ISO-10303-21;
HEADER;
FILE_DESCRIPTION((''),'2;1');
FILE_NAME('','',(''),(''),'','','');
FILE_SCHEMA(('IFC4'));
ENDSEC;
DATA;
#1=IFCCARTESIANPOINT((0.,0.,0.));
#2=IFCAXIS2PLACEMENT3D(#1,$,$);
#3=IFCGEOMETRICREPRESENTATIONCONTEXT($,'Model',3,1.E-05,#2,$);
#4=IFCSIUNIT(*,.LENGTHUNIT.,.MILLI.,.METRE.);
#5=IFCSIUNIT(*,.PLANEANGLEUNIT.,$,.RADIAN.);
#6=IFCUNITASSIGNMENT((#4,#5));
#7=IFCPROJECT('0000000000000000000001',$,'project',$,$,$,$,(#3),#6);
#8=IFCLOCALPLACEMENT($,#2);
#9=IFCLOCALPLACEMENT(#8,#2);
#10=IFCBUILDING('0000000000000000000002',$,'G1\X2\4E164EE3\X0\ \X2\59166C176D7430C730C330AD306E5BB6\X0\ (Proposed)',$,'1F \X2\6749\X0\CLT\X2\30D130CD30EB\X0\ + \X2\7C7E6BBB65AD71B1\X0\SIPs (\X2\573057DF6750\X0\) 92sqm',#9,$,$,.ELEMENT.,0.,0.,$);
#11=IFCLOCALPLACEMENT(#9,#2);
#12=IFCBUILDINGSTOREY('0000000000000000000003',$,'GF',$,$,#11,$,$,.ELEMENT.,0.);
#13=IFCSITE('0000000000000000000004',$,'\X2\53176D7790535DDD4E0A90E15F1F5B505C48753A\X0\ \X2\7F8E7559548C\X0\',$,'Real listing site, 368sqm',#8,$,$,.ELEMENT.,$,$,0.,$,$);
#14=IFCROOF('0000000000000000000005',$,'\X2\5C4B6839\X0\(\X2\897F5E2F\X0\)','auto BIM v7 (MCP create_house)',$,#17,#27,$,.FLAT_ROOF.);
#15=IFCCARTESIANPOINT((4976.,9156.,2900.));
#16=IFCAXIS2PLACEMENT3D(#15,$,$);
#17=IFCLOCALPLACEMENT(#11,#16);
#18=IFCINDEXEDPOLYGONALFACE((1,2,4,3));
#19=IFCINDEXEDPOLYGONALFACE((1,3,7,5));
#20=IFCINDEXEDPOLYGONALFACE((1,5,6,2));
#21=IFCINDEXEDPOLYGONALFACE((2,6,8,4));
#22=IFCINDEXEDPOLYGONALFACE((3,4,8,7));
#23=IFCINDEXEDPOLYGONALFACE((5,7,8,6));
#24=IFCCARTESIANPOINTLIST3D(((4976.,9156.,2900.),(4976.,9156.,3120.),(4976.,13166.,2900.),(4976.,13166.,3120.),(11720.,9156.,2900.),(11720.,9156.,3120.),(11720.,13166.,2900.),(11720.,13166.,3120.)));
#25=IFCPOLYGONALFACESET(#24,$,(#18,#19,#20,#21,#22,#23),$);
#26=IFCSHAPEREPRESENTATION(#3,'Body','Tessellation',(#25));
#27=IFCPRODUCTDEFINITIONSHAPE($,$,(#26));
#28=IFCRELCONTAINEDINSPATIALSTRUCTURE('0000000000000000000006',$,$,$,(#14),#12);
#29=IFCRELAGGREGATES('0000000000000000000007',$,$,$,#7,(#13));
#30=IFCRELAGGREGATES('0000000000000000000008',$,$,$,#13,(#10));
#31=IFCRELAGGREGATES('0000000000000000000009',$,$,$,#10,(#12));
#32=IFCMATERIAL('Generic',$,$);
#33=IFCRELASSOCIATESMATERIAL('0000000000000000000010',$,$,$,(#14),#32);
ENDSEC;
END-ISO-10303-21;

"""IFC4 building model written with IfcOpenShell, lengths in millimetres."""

from ifc_helpers import new_model, si_unit, frame, frame_2d, origin, place, context, project, spatial, rectangle, extrude, material, element, save


model = new_model("IFC4")

# Units and contexts
model_context = context("Model", 3, precision=1e-05, world=origin())
ifc_project = project(units=[si_unit("LENGTHUNIT", "METRE", prefix="MILLI"), si_unit("PLANEANGLEUNIT", "RADIAN")], contexts=[model_context])

# Site, building, storey
site_placement = place(None, origin())
site = spatial("IfcSite", under=ifc_project, at=site_placement, Name="北海道川上郡弟子屈町 美留和", ObjectType="Real listing site, 368sqm", CompositionType="ELEMENT", RefElevation=0.0)
building_placement = place(site_placement, origin())
building = spatial("IfcBuilding", under=site, at=building_placement, Name="G1世代 外気浴デッキの家 (Proposed)", ObjectType="1F 杉CLTパネル + 籾殻断熱SIPs (地域材) 92sqm", CompositionType="ELEMENT", ElevationOfRefHeight=0.0, ElevationOfTerrain=0.0)
storey_placement = place(building_placement, origin())
storey = spatial("IfcBuildingStorey", under=building, at=storey_placement, Name="GF", CompositionType="ELEMENT", Elevation=0.0)

# Shared definitions
ifc_material = material(Name="Generic")

# Roof
roof_1_placement = place(storey_placement, frame((4976.0, 9156.0, 2900.0)))
element("IfcRoof", 1, at=roof_1_placement, inside=storey, material=ifc_material, Name="屋根(西帯)", Description="auto BIM v7 (MCP create_house)", PredefinedType="FLAT_ROOF", context=model_context, shape_type="SweptSolid", body=[
    extrude(rectangle(XDim=6744.0, YDim=4010.0, at=frame_2d((3372.0, 2005.0))), frame((4976.0, 9156.0, 2900.0)), (0.0, 0.0, 1.0), 220.0),
])

save(model, "model.ifc")
